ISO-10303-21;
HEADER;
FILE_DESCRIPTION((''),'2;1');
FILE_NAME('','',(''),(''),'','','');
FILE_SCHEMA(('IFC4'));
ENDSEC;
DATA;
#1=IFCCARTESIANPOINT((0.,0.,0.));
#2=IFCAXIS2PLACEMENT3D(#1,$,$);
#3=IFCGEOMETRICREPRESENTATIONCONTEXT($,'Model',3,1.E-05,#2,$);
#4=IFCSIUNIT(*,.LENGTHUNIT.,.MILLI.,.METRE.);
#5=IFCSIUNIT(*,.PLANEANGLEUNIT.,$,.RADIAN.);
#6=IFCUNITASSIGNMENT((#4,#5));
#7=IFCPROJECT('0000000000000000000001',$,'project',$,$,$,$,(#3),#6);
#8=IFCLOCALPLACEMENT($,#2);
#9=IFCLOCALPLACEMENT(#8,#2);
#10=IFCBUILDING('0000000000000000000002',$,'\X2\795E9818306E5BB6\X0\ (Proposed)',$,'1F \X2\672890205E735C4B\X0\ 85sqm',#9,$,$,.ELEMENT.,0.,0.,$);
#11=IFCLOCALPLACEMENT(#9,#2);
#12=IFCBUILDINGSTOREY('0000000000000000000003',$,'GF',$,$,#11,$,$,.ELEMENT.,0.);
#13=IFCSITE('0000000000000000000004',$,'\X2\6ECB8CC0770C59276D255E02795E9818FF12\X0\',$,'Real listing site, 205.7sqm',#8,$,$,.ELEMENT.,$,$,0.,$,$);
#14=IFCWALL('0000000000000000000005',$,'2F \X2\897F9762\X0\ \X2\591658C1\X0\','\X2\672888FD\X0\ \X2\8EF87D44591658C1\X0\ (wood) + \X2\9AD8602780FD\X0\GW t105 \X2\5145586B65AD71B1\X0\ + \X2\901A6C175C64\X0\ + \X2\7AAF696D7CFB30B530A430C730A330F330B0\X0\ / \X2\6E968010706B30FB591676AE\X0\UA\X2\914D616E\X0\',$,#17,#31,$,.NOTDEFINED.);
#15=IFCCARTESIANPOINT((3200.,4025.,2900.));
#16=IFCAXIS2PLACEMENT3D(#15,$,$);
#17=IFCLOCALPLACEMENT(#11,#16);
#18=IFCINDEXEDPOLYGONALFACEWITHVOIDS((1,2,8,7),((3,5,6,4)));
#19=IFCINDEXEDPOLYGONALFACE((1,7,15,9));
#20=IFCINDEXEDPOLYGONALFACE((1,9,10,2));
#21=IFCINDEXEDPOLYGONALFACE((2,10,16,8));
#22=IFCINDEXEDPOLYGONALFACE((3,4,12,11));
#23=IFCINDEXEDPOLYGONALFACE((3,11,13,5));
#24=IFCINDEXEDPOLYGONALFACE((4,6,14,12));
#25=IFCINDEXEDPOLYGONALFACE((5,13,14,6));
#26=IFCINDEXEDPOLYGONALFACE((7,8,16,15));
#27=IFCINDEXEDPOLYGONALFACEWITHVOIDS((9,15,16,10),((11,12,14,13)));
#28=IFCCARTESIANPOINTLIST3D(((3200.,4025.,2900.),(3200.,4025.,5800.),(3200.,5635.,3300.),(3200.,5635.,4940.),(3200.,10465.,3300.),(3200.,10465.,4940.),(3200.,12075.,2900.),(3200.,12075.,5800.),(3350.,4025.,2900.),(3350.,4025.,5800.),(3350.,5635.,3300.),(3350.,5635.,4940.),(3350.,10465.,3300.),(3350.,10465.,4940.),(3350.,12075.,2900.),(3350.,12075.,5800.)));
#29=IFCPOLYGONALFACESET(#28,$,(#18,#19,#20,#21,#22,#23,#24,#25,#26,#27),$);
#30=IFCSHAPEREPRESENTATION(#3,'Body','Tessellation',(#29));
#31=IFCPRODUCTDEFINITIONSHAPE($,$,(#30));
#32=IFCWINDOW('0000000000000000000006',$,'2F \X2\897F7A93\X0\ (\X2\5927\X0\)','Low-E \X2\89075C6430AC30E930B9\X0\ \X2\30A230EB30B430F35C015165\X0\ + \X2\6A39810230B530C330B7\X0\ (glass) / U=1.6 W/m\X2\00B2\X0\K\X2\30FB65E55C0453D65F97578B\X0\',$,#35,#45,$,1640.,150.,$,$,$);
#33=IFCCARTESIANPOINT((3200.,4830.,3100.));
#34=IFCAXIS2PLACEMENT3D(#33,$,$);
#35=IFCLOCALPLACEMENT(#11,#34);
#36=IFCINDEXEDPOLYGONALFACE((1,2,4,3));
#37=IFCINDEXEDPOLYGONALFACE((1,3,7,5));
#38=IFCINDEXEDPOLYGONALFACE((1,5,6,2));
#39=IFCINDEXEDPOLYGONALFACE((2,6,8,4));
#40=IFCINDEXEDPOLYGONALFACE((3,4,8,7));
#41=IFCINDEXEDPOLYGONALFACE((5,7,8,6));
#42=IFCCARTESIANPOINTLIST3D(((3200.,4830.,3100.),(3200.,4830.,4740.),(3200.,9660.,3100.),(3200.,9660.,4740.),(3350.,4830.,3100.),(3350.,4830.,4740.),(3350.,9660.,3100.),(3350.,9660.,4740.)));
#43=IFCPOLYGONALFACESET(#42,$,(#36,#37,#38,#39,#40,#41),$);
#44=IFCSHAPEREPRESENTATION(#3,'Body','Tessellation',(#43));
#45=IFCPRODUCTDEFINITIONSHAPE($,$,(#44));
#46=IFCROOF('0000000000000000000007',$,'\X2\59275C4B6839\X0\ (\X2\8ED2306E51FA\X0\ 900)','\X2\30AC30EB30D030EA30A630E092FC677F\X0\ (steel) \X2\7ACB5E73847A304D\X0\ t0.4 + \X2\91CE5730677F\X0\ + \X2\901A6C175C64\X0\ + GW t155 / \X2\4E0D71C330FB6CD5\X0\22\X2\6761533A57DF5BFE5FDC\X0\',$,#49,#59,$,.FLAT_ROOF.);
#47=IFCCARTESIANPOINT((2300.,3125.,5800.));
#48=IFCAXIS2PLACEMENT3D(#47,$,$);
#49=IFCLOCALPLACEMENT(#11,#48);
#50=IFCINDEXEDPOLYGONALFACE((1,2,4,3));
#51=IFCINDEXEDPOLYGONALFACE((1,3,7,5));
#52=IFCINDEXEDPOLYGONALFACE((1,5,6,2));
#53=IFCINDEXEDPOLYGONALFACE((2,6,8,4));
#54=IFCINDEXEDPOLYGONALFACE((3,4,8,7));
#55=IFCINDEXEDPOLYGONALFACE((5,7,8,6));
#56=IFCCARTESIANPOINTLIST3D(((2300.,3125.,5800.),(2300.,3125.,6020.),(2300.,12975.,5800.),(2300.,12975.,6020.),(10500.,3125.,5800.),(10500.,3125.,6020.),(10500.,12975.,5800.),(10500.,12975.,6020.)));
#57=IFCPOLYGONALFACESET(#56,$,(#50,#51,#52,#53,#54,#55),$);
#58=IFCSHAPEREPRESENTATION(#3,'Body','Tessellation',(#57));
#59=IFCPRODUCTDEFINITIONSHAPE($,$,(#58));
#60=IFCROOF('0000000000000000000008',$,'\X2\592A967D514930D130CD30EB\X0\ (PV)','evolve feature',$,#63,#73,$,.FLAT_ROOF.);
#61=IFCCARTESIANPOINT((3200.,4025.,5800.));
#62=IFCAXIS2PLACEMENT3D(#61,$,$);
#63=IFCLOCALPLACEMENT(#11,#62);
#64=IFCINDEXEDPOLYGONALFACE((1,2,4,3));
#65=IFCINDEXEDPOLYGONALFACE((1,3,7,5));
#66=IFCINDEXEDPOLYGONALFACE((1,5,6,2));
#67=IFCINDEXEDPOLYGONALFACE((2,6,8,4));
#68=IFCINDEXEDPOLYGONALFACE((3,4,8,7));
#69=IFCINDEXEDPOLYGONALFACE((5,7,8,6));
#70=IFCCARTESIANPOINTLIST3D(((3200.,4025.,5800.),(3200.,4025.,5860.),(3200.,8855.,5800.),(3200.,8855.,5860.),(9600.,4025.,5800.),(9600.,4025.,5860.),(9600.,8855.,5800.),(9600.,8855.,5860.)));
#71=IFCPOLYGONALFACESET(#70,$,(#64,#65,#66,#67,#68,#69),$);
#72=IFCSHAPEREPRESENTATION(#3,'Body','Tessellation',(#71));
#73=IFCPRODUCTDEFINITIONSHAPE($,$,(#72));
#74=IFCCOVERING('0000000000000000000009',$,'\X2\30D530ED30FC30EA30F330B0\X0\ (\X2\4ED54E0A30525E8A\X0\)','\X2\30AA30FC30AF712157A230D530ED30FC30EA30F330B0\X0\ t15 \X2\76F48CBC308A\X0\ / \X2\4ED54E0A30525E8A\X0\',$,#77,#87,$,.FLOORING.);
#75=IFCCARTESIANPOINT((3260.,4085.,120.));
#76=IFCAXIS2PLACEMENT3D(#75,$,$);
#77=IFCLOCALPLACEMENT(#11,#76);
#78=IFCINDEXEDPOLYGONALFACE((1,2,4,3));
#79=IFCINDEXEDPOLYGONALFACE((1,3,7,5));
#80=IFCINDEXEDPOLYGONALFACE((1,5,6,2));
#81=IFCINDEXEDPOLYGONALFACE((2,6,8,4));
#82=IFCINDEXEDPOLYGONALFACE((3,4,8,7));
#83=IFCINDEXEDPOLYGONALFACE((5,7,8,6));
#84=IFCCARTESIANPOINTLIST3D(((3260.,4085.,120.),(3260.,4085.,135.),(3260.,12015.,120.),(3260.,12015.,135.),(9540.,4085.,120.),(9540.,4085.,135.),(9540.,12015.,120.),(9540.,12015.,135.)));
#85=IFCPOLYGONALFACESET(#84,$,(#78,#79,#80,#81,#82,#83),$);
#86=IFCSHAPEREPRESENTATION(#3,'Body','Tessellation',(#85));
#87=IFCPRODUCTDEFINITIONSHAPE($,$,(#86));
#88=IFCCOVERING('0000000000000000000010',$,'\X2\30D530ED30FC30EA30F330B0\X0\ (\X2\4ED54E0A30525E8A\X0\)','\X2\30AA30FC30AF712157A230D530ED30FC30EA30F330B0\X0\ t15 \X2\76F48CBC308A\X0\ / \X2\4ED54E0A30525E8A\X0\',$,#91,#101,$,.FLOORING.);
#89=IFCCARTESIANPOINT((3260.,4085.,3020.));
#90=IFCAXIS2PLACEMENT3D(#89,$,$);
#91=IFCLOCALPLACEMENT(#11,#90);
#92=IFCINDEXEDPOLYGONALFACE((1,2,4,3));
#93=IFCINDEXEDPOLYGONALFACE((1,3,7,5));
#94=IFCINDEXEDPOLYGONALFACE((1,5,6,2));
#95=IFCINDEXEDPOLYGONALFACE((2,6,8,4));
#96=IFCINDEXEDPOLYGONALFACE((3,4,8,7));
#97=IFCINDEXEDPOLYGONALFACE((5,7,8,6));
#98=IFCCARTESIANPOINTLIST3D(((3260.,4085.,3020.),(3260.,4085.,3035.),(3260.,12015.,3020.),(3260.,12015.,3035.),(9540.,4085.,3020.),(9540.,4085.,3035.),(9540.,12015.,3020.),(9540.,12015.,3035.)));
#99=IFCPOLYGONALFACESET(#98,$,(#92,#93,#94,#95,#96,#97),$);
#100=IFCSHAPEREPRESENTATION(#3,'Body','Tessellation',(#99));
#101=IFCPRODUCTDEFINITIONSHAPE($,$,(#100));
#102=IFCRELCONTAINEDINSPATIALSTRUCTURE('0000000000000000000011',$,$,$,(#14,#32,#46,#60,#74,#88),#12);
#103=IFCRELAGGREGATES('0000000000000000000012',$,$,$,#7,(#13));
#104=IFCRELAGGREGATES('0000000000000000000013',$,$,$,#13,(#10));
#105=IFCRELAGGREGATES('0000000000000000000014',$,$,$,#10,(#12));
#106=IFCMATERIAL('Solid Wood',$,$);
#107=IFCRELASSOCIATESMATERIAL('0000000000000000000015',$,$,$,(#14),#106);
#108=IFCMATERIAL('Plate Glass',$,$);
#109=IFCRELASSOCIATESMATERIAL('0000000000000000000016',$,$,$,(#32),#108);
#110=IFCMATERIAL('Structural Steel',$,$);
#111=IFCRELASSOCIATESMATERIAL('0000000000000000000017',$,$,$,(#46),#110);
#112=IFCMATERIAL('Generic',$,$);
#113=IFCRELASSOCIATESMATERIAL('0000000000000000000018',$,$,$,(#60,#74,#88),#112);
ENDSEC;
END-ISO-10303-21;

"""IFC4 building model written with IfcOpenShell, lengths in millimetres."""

from ifc_helpers import new_model, si_unit, frame, frame_2d, origin, place, context, project, spatial, rectangle, extrude, material, element, fill, save


model = new_model("IFC4")

# Units and contexts
model_context = context("Model", 3, precision=1e-05, world=origin())
ifc_project = project(units=[si_unit("LENGTHUNIT", "METRE", prefix="MILLI"), si_unit("PLANEANGLEUNIT", "RADIAN")], contexts=[model_context])

# Site, building, storey
site_placement = place(None, origin())
site = spatial("IfcSite", under=ifc_project, at=site_placement, Name="滋賀県大津市神領２", ObjectType="Real listing site, 205.7sqm", CompositionType="ELEMENT", RefElevation=0.0)
building_placement = place(site_placement, origin())
building = spatial("IfcBuilding", under=site, at=building_placement, Name="神領の家 (Proposed)", ObjectType="1F 木造平屋 85sqm", CompositionType="ELEMENT", ElevationOfRefHeight=0.0, ElevationOfTerrain=0.0)
storey_placement = place(building_placement, origin())
storey = spatial("IfcBuildingStorey", under=building, at=storey_placement, Name="GF", CompositionType="ELEMENT", Elevation=0.0)

# Shared definitions
ifc_material_1 = material(Name="Solid Wood")
ifc_material_2 = material(Name="Generic")

# Shared definitions
ifc_material_3 = material(Name="Plate Glass")

# Wall, opening, window
wall_1_placement = place(storey_placement, frame((3200.0, 4025.0, 2900.0)))
wall_1 = element("IfcWall", 1, at=wall_1_placement, inside=storey, material=ifc_material_1, Name="2F 西面 外壁", Description="木製 軸組外壁 (wood) + 高性能GW t105 充填断熱 + 通気層 + 窯業系サイディング / 準耐火・外皮UA配慮", PredefinedType="NOTDEFINED", context=model_context, shape_type="SweptSolid", body=[
    extrude(rectangle(XDim=150.0, YDim=8050.0, at=frame_2d((75.0, 4025.0))), frame((3200.0, 4025.0, 2900.0)), (0.0, 0.0, 1.0), 2900.0),
])
opening_1_placement = place(storey_placement, frame((3200.0, 4830.0, 3100.0)))
opening_1 = element("IfcOpeningElement", 2, at=opening_1_placement, cuts=wall_1, PredefinedType="NOTDEFINED", context=model_context, shape_type="SweptSolid", body=[
    extrude(rectangle(XDim=150.0, YDim=4830.0, at=frame_2d((75.0, 2415.0))), frame((3200.0, 4830.0, 3100.0)), (0.0, 0.0, 1.0), 1640.0),
])
window_1_placement = place(storey_placement, frame((3200.0, 4830.0, 3100.0)))
window_1 = element("IfcWindow", 3, at=window_1_placement, inside=storey, material=ifc_material_3, Name="2F 西窓 (大)", Description="Low-E 複層ガラス アルゴン封入 + 樹脂サッシ (glass) / U=1.6 W/m²K・日射取得型", OverallHeight=1640.0, OverallWidth=150.0, context=model_context, shape_type="SweptSolid", body=[
    extrude(rectangle(XDim=150.0, YDim=4830.0, at=frame_2d((75.0, 2415.0))), frame((3200.0, 4830.0, 3100.0)), (0.0, 0.0, 1.0), 1640.0),
])
fill(opening_1, window_1)

# Roofs
ifc_material_4 = material(Name="Structural Steel")
roof_1_placement = place(storey_placement, frame((2300.0, 3125.0, 5800.0)))
element("IfcRoof", 4, at=roof_1_placement, inside=storey, material=ifc_material_4, Name="大屋根 (軒の出 900)", Description="ガルバリウム鋼板 (steel) 立平葺き t0.4 + 野地板 + 通気層 + GW t155 / 不燃・法22条区域対応", PredefinedType="FLAT_ROOF", context=model_context, shape_type="SweptSolid", body=[
    extrude(rectangle(XDim=8200.0, YDim=9850.0, at=frame_2d((4100.0, 4925.0))), frame((2300.0, 3125.0, 5800.0)), (0.0, 0.0, 1.0), 220.0),
])
roof_2_placement = place(storey_placement, frame((3200.0, 4025.0, 5800.0)))
element("IfcRoof", 5, at=roof_2_placement, inside=storey, material=ifc_material_2, Name="太陽光パネル (PV)", Description="evolve feature", PredefinedType="FLAT_ROOF", context=model_context, shape_type="SweptSolid", body=[
    extrude(rectangle(XDim=6400.0, YDim=4830.0, at=frame_2d((3200.0, 2415.0))), frame((3200.0, 4025.0, 5800.0)), (0.0, 0.0, 1.0), 60.0),
])

# Coverings
covering_1_placement = place(storey_placement, frame((3260.0, 4085.0, 120.0)))
element("IfcCovering", 6, at=covering_1_placement, inside=storey, material=ifc_material_2, Name="フローリング (仕上げ床)", Description="オーク無垢フローリング t15 直貼り / 仕上げ床", PredefinedType="FLOORING", context=model_context, shape_type="SweptSolid", body=[
    extrude(rectangle(XDim=6280.0, YDim=7930.0, at=frame_2d((3140.0, 3965.0))), frame((3260.0, 4085.0, 120.0)), (0.0, 0.0, 1.0), 15.0),
])
covering_2_placement = place(storey_placement, frame((3260.0, 4085.0, 3020.0)))
element("IfcCovering", 7, at=covering_2_placement, inside=storey, material=ifc_material_2, Name="フローリング (仕上げ床)", Description="オーク無垢フローリング t15 直貼り / 仕上げ床", PredefinedType="FLOORING", context=model_context, shape_type="SweptSolid", body=[
    extrude(rectangle(XDim=6280.0, YDim=7930.0, at=frame_2d((3140.0, 3965.0))), frame((3260.0, 4085.0, 3020.0)), (0.0, 0.0, 1.0), 15.0),
])

save(model, "model.ifc")
